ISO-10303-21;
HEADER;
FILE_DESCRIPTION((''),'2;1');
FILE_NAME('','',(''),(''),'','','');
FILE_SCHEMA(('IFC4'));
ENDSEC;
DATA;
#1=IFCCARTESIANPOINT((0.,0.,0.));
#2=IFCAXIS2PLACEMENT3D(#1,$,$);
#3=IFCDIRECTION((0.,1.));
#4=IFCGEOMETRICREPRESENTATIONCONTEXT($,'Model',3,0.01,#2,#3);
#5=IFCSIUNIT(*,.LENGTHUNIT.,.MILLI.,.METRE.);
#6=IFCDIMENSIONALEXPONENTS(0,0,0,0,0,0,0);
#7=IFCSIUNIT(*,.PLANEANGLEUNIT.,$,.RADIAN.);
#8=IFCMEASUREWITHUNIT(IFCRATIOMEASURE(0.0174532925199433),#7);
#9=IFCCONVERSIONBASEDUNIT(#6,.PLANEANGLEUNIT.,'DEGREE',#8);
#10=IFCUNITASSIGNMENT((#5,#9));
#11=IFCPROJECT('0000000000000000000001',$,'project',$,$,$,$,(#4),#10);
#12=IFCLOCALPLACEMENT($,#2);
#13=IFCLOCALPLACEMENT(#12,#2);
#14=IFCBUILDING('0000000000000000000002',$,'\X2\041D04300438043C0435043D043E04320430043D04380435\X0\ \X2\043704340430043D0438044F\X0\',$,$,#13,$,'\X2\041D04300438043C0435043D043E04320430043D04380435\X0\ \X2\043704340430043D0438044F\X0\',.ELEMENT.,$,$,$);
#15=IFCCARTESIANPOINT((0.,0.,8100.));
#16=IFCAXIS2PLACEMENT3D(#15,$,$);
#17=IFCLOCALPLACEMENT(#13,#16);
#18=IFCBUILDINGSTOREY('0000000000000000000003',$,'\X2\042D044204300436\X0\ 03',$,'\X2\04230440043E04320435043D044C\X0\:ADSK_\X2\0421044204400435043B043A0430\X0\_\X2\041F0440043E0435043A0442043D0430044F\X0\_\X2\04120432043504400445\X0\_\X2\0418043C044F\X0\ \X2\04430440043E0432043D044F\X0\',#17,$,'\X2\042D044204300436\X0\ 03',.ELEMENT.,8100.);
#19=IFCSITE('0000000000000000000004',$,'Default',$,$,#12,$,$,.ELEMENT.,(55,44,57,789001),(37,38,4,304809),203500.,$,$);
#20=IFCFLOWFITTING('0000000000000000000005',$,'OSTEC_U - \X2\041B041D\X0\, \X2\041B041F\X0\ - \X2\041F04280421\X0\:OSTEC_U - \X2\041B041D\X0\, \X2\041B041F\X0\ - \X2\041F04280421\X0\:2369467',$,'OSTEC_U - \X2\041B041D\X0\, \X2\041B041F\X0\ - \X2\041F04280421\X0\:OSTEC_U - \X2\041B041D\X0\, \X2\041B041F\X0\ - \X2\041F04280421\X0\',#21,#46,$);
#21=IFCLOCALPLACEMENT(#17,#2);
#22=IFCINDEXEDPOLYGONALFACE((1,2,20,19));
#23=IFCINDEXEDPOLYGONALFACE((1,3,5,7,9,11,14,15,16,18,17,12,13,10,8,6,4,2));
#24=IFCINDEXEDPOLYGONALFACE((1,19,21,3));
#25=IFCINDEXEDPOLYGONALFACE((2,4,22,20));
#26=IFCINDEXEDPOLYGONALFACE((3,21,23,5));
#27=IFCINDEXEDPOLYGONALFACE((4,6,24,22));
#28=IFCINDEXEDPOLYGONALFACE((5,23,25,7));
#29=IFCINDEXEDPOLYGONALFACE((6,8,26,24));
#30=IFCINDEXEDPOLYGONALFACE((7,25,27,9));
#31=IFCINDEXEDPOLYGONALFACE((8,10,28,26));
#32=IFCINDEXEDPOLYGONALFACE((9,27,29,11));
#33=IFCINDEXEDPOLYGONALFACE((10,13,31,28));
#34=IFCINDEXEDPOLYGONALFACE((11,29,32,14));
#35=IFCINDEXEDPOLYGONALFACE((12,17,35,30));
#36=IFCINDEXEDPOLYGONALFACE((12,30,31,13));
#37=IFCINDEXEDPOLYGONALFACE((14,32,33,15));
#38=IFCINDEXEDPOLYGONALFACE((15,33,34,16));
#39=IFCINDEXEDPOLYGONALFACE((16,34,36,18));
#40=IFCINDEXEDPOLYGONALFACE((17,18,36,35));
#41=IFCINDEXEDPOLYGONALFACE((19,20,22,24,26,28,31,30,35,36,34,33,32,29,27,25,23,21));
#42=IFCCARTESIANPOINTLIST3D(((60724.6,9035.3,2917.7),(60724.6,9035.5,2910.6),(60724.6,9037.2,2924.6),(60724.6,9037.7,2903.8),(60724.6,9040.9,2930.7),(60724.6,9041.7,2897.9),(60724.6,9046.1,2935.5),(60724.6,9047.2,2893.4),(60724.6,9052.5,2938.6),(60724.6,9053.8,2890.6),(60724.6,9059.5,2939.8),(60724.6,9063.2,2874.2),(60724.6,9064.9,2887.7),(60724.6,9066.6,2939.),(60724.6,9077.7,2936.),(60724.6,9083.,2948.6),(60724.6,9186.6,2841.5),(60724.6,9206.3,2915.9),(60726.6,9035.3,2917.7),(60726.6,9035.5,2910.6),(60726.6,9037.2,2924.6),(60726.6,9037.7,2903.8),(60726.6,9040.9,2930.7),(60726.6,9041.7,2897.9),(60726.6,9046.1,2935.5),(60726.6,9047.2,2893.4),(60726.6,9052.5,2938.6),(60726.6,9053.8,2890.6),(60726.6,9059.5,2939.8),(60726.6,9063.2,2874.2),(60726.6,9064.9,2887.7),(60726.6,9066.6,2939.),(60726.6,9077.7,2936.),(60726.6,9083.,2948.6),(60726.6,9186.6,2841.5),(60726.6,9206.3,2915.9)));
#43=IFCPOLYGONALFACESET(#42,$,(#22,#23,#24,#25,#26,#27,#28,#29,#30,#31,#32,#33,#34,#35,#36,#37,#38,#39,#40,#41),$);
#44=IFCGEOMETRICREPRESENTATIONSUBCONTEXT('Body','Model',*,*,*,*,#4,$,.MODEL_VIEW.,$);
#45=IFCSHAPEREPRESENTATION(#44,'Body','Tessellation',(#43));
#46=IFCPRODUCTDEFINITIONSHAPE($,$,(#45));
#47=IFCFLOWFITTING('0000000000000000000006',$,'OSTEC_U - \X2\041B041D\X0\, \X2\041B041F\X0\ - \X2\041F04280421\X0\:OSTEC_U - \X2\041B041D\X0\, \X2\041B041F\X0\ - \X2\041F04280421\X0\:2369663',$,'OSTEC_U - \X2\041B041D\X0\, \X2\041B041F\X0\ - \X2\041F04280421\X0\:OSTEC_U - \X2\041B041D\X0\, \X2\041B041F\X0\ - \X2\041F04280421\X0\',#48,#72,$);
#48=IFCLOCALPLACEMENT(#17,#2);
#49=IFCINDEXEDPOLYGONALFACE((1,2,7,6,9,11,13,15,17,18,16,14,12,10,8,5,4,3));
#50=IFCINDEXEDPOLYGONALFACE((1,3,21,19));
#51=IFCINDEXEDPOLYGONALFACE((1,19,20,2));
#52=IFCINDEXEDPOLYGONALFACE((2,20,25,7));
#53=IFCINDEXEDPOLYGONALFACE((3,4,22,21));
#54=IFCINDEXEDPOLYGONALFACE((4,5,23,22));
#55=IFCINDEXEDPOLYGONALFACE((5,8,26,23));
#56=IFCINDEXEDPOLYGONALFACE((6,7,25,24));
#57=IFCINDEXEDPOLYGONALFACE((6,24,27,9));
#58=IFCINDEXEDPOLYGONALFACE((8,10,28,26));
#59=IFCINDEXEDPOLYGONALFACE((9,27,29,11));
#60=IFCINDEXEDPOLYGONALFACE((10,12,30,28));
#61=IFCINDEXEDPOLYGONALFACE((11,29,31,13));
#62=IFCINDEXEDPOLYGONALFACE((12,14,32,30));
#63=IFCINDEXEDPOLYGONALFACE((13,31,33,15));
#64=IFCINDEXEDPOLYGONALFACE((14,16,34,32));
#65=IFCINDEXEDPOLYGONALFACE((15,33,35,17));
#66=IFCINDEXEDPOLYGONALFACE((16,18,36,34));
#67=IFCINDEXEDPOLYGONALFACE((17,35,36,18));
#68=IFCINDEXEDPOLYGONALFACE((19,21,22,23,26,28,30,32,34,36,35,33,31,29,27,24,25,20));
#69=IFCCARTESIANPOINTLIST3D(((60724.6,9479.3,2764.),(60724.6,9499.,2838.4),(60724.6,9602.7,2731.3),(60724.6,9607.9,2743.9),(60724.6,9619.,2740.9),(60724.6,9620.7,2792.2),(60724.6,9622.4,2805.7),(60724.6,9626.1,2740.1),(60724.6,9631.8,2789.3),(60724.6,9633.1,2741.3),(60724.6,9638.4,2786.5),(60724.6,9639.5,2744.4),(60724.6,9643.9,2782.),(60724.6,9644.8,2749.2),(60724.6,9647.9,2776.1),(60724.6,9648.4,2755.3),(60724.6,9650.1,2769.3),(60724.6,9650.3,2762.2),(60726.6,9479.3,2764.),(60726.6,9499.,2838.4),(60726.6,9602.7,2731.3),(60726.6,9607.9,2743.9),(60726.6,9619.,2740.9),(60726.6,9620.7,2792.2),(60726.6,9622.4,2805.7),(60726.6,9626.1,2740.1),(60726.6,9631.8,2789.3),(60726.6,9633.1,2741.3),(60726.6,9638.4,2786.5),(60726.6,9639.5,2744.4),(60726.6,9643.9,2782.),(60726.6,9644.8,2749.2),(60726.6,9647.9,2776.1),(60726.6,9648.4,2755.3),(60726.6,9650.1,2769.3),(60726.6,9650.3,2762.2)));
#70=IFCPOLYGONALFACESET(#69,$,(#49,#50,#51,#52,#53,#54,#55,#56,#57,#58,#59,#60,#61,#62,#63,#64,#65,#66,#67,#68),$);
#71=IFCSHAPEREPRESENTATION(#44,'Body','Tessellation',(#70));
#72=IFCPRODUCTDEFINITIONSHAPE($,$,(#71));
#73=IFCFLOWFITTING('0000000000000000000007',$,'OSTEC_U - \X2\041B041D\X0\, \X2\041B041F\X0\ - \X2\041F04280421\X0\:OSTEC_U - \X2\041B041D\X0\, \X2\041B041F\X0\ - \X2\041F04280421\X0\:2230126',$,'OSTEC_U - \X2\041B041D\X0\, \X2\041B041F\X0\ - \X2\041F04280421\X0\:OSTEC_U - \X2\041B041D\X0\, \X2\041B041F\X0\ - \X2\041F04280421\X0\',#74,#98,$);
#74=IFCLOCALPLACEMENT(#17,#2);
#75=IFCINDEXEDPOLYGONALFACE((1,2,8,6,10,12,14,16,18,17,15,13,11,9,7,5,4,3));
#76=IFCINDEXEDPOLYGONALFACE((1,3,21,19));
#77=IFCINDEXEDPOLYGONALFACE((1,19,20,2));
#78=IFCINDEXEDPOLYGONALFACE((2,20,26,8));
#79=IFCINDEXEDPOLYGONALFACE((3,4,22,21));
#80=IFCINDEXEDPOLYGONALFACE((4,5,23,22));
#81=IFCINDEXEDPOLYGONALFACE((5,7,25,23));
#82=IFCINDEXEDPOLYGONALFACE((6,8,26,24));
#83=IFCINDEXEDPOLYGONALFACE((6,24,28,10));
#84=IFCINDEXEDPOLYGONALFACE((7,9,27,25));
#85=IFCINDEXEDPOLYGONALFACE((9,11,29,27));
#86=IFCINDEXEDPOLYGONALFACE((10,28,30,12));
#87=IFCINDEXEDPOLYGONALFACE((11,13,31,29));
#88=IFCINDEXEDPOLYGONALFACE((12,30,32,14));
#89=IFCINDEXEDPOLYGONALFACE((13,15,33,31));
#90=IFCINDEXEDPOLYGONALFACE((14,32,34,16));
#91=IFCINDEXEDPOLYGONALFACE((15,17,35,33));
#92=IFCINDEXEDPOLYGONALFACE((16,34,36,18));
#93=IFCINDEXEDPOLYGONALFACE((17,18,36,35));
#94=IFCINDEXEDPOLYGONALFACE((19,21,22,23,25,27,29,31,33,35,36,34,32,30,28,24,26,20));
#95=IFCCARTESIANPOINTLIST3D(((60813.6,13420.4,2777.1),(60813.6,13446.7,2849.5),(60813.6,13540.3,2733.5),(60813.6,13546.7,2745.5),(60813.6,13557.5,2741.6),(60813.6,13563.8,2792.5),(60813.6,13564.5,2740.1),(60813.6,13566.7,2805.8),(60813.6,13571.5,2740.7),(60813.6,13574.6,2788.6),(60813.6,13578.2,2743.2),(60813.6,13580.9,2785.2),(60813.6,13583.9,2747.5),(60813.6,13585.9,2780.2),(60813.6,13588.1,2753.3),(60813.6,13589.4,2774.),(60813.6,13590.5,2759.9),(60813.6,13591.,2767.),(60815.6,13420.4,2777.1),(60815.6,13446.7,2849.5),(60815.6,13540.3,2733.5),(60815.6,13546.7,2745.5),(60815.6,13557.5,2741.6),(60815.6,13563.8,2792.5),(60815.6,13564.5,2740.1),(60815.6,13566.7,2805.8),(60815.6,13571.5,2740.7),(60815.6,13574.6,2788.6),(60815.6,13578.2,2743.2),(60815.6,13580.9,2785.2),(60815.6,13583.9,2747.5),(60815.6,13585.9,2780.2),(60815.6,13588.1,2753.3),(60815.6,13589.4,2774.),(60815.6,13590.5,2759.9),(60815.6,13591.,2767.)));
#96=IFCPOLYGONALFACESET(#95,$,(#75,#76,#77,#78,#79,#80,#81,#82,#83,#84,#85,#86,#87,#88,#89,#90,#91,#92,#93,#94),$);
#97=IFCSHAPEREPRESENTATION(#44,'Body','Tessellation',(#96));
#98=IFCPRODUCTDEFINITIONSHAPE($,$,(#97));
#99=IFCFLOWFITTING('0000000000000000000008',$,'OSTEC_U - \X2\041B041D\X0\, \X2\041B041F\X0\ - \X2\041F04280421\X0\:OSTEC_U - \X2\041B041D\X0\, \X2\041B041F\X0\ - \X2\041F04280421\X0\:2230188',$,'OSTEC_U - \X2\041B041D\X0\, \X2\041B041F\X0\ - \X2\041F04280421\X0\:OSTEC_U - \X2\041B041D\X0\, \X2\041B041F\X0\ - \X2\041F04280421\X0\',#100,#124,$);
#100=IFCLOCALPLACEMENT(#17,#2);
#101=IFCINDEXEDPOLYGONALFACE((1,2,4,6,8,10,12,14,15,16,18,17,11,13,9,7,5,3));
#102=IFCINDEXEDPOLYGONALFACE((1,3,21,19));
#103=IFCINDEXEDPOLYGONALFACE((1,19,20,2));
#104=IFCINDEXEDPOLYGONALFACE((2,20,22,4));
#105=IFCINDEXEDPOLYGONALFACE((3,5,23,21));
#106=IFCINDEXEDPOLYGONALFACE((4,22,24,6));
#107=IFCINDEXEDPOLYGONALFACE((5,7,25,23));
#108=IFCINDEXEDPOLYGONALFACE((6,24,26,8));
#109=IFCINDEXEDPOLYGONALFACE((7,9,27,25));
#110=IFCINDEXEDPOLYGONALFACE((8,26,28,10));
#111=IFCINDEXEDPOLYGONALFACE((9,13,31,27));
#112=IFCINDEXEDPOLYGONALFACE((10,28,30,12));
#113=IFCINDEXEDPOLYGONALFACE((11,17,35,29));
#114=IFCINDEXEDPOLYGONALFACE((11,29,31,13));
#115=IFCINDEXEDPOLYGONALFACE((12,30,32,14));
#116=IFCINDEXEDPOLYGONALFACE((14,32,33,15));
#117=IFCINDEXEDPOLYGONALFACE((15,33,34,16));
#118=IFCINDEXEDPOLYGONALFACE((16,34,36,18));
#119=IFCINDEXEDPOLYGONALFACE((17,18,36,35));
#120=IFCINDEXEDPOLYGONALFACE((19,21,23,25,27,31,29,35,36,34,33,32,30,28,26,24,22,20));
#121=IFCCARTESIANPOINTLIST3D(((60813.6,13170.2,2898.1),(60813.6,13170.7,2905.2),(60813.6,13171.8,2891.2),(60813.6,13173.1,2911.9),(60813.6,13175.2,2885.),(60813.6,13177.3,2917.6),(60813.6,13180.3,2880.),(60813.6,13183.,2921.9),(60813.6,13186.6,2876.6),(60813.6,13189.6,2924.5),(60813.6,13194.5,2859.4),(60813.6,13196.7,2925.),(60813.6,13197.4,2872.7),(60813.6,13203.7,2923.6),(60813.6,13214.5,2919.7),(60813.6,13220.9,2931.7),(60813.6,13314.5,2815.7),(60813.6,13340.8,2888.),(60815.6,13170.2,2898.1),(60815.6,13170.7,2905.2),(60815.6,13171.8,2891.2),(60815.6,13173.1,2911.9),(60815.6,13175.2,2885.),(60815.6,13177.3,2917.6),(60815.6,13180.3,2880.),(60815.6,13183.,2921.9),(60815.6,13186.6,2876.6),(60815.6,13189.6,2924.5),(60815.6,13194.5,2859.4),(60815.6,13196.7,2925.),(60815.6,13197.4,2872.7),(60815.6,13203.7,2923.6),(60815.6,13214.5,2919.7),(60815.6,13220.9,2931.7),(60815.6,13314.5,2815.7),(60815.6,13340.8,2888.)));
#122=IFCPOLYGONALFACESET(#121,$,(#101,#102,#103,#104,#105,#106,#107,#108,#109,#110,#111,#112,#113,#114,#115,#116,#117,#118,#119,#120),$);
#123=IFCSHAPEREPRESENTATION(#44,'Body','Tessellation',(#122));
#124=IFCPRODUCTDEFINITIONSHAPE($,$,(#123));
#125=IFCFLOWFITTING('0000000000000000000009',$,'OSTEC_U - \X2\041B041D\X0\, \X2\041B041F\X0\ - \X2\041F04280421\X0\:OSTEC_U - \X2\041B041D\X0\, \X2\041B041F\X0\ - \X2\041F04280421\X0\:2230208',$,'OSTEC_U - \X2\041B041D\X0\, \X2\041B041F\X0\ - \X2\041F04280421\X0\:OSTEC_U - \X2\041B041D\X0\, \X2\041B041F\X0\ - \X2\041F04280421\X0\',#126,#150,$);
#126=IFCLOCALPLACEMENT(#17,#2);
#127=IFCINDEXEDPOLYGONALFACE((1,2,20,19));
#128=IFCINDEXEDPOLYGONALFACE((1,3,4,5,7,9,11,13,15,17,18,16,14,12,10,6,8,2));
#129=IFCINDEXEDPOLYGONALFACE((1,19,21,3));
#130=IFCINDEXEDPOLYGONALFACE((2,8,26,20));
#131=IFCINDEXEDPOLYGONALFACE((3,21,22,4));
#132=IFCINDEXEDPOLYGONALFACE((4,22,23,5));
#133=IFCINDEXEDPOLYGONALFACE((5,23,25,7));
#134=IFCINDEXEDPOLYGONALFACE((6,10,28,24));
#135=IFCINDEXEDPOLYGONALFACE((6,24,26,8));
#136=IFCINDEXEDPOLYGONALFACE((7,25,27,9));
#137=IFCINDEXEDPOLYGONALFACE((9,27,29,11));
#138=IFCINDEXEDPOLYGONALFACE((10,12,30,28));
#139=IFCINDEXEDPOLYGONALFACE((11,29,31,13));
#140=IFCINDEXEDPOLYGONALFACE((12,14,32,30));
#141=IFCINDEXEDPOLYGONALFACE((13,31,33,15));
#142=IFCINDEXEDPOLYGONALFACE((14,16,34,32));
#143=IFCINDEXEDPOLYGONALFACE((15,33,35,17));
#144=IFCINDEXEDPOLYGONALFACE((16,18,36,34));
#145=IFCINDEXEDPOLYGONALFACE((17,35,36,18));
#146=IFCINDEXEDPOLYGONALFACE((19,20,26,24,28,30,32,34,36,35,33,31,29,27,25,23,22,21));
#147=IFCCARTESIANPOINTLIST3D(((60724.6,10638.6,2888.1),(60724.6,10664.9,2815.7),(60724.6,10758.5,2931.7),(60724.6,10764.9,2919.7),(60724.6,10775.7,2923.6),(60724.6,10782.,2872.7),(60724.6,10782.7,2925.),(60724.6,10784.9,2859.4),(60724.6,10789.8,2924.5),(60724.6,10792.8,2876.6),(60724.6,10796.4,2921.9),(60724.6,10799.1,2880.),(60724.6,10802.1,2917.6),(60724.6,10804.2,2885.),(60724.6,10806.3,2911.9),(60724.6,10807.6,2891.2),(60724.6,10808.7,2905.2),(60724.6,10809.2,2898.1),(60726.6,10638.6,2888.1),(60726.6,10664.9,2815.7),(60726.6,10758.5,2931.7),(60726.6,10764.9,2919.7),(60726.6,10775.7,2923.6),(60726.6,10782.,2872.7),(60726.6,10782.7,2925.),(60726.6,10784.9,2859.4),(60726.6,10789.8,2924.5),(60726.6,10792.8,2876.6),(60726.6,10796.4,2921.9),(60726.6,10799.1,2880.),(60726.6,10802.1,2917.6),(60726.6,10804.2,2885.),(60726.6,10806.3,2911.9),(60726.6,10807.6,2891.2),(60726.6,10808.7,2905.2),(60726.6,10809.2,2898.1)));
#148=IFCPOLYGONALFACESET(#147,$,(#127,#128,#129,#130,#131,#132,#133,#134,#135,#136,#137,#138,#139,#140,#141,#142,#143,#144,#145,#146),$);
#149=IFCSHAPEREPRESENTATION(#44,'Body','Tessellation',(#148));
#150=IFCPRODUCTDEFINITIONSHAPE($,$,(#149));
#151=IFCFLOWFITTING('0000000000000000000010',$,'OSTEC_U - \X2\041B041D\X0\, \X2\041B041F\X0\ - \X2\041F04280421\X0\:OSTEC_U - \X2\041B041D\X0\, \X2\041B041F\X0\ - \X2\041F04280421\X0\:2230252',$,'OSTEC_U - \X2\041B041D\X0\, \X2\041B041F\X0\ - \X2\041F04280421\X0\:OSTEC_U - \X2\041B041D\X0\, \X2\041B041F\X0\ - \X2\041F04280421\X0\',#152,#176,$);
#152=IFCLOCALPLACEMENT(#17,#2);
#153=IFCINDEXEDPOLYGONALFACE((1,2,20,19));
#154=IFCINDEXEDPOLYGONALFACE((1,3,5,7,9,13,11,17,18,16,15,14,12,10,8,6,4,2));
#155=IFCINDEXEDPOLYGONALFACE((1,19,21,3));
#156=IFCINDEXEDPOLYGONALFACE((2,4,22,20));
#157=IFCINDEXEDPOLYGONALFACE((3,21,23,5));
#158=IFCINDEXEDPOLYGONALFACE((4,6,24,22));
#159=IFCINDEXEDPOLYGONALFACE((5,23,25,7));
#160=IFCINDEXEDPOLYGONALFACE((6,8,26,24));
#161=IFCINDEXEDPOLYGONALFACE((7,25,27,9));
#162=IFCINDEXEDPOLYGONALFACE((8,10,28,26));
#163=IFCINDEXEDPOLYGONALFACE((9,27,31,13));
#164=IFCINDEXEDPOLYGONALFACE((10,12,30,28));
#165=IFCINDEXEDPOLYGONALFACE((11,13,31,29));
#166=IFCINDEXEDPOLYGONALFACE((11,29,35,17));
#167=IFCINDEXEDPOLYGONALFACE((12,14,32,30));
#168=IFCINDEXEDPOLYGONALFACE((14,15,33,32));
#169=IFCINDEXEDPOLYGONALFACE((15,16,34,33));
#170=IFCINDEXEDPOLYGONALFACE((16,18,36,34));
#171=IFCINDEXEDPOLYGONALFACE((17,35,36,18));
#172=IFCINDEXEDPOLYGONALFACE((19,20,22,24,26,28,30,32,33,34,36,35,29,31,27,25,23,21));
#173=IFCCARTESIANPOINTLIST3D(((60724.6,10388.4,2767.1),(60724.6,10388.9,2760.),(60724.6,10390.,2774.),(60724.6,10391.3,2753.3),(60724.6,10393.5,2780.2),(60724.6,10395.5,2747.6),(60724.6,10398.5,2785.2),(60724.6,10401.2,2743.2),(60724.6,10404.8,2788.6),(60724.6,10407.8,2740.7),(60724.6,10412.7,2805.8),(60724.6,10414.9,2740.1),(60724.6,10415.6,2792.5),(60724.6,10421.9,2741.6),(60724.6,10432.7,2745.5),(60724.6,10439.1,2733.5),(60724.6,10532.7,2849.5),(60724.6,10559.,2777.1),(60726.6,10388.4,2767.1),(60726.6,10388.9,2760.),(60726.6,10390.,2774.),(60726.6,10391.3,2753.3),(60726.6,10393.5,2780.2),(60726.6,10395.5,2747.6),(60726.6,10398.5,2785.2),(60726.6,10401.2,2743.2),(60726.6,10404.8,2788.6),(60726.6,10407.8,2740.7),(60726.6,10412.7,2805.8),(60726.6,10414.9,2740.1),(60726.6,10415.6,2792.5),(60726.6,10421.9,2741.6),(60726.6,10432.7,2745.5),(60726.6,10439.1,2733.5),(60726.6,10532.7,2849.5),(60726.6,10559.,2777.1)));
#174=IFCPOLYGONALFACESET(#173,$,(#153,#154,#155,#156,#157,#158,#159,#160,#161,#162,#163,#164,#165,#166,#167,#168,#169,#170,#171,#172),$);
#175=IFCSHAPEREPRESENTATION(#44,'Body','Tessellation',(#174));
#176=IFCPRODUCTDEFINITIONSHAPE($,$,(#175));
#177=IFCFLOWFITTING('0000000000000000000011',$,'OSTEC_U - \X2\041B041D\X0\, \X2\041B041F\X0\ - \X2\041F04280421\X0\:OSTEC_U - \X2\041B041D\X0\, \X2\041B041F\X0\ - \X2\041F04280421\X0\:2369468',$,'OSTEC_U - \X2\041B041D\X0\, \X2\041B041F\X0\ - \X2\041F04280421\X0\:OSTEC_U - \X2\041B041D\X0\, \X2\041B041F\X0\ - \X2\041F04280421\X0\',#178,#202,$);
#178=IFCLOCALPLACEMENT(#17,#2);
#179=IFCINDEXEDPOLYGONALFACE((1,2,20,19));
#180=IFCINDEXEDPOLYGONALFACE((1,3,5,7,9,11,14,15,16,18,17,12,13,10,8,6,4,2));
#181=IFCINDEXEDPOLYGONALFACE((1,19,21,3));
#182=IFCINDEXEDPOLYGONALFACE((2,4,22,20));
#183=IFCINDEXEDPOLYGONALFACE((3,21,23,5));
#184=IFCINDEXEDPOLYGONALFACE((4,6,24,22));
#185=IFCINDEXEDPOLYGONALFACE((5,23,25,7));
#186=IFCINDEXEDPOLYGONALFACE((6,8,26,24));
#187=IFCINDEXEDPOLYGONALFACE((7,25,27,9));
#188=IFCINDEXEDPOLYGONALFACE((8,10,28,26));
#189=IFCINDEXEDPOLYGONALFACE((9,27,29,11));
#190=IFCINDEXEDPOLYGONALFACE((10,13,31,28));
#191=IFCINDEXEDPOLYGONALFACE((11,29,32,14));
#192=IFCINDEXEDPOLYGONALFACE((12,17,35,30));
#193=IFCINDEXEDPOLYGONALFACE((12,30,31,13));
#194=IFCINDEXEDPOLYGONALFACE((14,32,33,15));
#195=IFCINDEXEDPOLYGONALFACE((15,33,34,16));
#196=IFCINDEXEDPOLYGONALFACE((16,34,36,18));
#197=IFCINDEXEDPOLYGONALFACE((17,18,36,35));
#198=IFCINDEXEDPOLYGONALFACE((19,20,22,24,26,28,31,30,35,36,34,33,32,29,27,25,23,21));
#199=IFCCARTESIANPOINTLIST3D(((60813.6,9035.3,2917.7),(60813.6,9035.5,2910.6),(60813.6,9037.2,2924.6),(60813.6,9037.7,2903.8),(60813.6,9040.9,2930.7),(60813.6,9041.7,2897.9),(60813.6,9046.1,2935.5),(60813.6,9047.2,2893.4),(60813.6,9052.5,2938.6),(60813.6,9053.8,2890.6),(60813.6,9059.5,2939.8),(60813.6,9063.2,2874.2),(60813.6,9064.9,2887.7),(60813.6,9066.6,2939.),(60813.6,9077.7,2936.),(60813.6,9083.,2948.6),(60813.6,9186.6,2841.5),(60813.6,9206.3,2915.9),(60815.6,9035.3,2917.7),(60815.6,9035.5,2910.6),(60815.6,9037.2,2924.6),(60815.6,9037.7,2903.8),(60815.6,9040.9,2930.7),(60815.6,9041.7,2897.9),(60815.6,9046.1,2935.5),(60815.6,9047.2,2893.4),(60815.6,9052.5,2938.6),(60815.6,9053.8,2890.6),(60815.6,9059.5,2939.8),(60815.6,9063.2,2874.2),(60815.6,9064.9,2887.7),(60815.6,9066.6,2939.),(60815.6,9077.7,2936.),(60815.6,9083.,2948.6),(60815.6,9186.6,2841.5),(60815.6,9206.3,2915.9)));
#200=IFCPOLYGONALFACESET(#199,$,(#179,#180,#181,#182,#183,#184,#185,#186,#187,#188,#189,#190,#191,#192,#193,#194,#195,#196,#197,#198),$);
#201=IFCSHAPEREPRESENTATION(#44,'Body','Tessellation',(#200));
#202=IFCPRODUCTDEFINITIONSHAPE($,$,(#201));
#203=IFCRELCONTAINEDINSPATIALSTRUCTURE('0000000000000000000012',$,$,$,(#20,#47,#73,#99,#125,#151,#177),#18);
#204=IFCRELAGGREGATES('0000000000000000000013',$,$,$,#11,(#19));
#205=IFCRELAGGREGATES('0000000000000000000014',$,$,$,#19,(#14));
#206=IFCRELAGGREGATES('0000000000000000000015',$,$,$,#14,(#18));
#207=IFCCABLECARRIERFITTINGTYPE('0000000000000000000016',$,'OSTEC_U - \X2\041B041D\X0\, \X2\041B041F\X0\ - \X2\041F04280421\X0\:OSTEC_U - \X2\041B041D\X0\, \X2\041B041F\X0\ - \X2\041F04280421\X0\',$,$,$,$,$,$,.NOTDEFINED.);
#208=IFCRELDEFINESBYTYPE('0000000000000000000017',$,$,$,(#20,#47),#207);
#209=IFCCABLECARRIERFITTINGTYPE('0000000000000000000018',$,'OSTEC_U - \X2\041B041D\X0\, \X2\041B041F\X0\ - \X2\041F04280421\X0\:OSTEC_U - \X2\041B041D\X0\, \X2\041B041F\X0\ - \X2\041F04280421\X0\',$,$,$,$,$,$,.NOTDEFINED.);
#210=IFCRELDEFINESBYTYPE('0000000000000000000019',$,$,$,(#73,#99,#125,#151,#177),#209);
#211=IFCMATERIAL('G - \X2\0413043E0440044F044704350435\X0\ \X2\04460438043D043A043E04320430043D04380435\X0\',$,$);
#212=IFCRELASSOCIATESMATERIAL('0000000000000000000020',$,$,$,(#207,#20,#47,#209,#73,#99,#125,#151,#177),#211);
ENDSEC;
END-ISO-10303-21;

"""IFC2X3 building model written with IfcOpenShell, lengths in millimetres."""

from ifc_helpers import new_model, entity, si_unit, converted_unit, direction, frame, frame_2d, origin, place, context, subcontext, project, spatial, polyline, circle_curve, parameter, trimmed, segment, composite_curve, outline, extrude, source, transform, mapped, material, type_object, type_shapes, element, save


model = new_model("IFC2X3")

# Units and contexts
model_context = context("Model", 3, precision=0.01, world=origin(), true_north=direction((0.0, 1.0)))
body_context = subcontext(model_context, "Body", "Model", "MODEL_VIEW")
ifc_project = project(units=[si_unit("LENGTHUNIT", "METRE", prefix="MILLI"), converted_unit("PLANEANGLEUNIT", "DEGREE", entity("IfcRatioMeasure", 0.0174532925199433), si_unit("PLANEANGLEUNIT", "RADIAN"), dimensions=[0, 0, 0, 0, 0, 0, 0])], contexts=[model_context])

# Site, building, storey
site_placement = place(None, frame((0.0, 0.0, 0.0)))
site = spatial("IfcSite", under=ifc_project, at=site_placement, Name="Default", CompositionType="ELEMENT", RefLatitude=(55, 44, 57, 789001), RefLongitude=(37, 38, 4, 304809), RefElevation=203500.0)
building_placement = place(site_placement, origin())
building = spatial("IfcBuilding", under=site, at=building_placement, Name="Наименование здания", LongName="Наименование здания", CompositionType="ELEMENT")
storey_placement = place(building_placement, frame((0.0, 0.0, 8100.0)))
storey = spatial("IfcBuildingStorey", under=building, at=storey_placement, Name="Этаж 03", ObjectType="Уровень:ADSK_Стрелка_Проектная_Вверх_Имя уровня", LongName="Этаж 03", CompositionType="ELEMENT", Elevation=8100.0)

# Flow fittings
ifc_material_1 = material(Name="G - Горячее цинкование")
cable_carrier_fitting_type_1 = type_object("IfcCableCarrierFittingType", Name="OSTEC_U - ЛН, ЛП - ПШС:OSTEC_U - ЛН, ЛП - ПШС", PredefinedType="NOTDEFINED", material=ifc_material_1)
shared_shape_1 = source(origin(), body_context, "Body", "SweptSolid", [
    extrude(outline(composite_curve([segment(trimmed(circle_curve(frame_2d((-41.5, 0.0), x_axis=(1.0, 0.0)), 25.0), [parameter(90.0)], [parameter(270.0)], True, "PARAMETER"), True, "CONTINUOUS"), segment(polyline([(-41.5, -25.0), (-30.0, -25.0)]), True, "CONTINUOUS"), segment(polyline([(-30.0, -25.0), (-28.1, -38.5)]), True, "CONTINUOUS"), segment(polyline([(-28.1, -38.5), (99.5, -38.5)]), True, "CONTINUOUS"), segment(polyline([(99.5, -38.5), (99.5, 38.5)]), True, "CONTINUOUS"), segment(polyline([(99.5, 38.5), (-28.1, 38.5)]), True, "CONTINUOUS"), segment(polyline([(-28.1, 38.5), (-30.0, 25.0)]), True, "CONTINUOUS"), segment(polyline([(-30.0, 25.0), (-41.5, 25.0)]), True, "CONTINUOUS")], self_intersect=False)), frame((41.5, 0.0, 0.0), z_axis=(0.0, 0.0, -1.0), x_axis=(1.0, 0.0, 0.0)), (0.0, 0.0, -1.0), 2.0),
])
type_shapes(cable_carrier_fitting_type_1, [shared_shape_1])
for number, where, z_axis, x_axis, name in (
    (1, (60726.6, 9060.2, 2914.8), (-1.0, 0.0, 0.0), (0.0, 0.966668, -0.256034), "OSTEC_U - ЛН, ЛП - ПШС:OSTEC_U - ЛН, ЛП - ПШС:2369467"),
    (2, (60726.6, 9625.4, 2765.1), (-1.0, 0.0, 0.0), (0.0, -0.966668, 0.256034), "OSTEC_U - ЛН, ЛП - ПШС:OSTEC_U - ЛН, ЛП - ПШС:2369663"),
):
    element("IfcFlowFitting", number, at=place(storey_placement, frame(where, z_axis=z_axis, x_axis=x_axis)), inside=storey, type_object=cable_carrier_fitting_type_1, material=ifc_material_1, Name=name, ObjectType="OSTEC_U - ЛН, ЛП - ПШС:OSTEC_U - ЛН, ЛП - ПШС", context=body_context, shape_type="MappedRepresentation", body=[
        mapped(shared_shape_1, transform((0.0, 0.0, 0.0), scale=1.0)),
    ])
cable_carrier_fitting_type_2 = type_object("IfcCableCarrierFittingType", Name="OSTEC_U - ЛН, ЛП - ПШС:OSTEC_U - ЛН, ЛП - ПШС", PredefinedType="NOTDEFINED", material=ifc_material_1)
shared_shape_2 = source(origin(), body_context, "Body", "SweptSolid", [
    extrude(outline(composite_curve([segment(trimmed(circle_curve(frame_2d((-41.5, 0.0), x_axis=(1.0, 0.0)), 25.0), [parameter(90.0)], [parameter(270.0)], True, "PARAMETER"), True, "CONTINUOUS"), segment(polyline([(-41.5, -25.0), (-30.0, -25.0)]), True, "CONTINUOUS"), segment(polyline([(-30.0, -25.0), (-28.1, -38.5)]), True, "CONTINUOUS"), segment(polyline([(-28.1, -38.5), (99.5, -38.5)]), True, "CONTINUOUS"), segment(polyline([(99.5, -38.5), (99.5, 38.5)]), True, "CONTINUOUS"), segment(polyline([(99.5, 38.5), (-28.1, 38.5)]), True, "CONTINUOUS"), segment(polyline([(-28.1, 38.5), (-30.0, 25.0)]), True, "CONTINUOUS"), segment(polyline([(-30.0, 25.0), (-41.5, 25.0)]), True, "CONTINUOUS")], self_intersect=False)), frame((41.5, 0.0, 0.0)), (0.0, 0.0, 1.0), 2.0),
])
type_shapes(cable_carrier_fitting_type_2, [shared_shape_2])
for number, where, z_axis, x_axis, name in (
    (3, (60813.6, 13566.0, 2765.1), (1.0, 0.0, 0.0), (0.0, -0.939662, 0.342104), "OSTEC_U - ЛН, ЛП - ПШС:OSTEC_U - ЛН, ЛП - ПШС:2230126"),
    (4, (60813.6, 13195.1, 2900.1), (1.0, 0.0, 0.0), (0.0, 0.939662, -0.342104), "OSTEC_U - ЛН, ЛП - ПШС:OSTEC_U - ЛН, ЛП - ПШС:2230188"),
    (5, (60726.6, 10784.3, 2900.1), (-1.0, 0.0, 0.0), (0.0, -0.939693, -0.34202), "OSTEC_U - ЛН, ЛП - ПШС:OSTEC_U - ЛН, ЛП - ПШС:2230208"),
    (6, (60726.6, 10413.3, 2765.1), (-1.0, 0.0, 0.0), (0.0, 0.939693, 0.34202), "OSTEC_U - ЛН, ЛП - ПШС:OSTEC_U - ЛН, ЛП - ПШС:2230252"),
    (7, (60813.6, 9060.2, 2914.8), (1.0, 0.0, 0.0), (0.0, 0.966668, -0.256034), "OSTEC_U - ЛН, ЛП - ПШС:OSTEC_U - ЛН, ЛП - ПШС:2369468"),
):
    element("IfcFlowFitting", number, at=place(storey_placement, frame(where, z_axis=z_axis, x_axis=x_axis)), inside=storey, type_object=cable_carrier_fitting_type_2, material=ifc_material_1, Name=name, ObjectType="OSTEC_U - ЛН, ЛП - ПШС:OSTEC_U - ЛН, ЛП - ПШС", context=body_context, shape_type="MappedRepresentation", body=[
        mapped(shared_shape_2, transform((0.0, 0.0, 0.0), scale=1.0)),
    ])

save(model, "model.ifc")
